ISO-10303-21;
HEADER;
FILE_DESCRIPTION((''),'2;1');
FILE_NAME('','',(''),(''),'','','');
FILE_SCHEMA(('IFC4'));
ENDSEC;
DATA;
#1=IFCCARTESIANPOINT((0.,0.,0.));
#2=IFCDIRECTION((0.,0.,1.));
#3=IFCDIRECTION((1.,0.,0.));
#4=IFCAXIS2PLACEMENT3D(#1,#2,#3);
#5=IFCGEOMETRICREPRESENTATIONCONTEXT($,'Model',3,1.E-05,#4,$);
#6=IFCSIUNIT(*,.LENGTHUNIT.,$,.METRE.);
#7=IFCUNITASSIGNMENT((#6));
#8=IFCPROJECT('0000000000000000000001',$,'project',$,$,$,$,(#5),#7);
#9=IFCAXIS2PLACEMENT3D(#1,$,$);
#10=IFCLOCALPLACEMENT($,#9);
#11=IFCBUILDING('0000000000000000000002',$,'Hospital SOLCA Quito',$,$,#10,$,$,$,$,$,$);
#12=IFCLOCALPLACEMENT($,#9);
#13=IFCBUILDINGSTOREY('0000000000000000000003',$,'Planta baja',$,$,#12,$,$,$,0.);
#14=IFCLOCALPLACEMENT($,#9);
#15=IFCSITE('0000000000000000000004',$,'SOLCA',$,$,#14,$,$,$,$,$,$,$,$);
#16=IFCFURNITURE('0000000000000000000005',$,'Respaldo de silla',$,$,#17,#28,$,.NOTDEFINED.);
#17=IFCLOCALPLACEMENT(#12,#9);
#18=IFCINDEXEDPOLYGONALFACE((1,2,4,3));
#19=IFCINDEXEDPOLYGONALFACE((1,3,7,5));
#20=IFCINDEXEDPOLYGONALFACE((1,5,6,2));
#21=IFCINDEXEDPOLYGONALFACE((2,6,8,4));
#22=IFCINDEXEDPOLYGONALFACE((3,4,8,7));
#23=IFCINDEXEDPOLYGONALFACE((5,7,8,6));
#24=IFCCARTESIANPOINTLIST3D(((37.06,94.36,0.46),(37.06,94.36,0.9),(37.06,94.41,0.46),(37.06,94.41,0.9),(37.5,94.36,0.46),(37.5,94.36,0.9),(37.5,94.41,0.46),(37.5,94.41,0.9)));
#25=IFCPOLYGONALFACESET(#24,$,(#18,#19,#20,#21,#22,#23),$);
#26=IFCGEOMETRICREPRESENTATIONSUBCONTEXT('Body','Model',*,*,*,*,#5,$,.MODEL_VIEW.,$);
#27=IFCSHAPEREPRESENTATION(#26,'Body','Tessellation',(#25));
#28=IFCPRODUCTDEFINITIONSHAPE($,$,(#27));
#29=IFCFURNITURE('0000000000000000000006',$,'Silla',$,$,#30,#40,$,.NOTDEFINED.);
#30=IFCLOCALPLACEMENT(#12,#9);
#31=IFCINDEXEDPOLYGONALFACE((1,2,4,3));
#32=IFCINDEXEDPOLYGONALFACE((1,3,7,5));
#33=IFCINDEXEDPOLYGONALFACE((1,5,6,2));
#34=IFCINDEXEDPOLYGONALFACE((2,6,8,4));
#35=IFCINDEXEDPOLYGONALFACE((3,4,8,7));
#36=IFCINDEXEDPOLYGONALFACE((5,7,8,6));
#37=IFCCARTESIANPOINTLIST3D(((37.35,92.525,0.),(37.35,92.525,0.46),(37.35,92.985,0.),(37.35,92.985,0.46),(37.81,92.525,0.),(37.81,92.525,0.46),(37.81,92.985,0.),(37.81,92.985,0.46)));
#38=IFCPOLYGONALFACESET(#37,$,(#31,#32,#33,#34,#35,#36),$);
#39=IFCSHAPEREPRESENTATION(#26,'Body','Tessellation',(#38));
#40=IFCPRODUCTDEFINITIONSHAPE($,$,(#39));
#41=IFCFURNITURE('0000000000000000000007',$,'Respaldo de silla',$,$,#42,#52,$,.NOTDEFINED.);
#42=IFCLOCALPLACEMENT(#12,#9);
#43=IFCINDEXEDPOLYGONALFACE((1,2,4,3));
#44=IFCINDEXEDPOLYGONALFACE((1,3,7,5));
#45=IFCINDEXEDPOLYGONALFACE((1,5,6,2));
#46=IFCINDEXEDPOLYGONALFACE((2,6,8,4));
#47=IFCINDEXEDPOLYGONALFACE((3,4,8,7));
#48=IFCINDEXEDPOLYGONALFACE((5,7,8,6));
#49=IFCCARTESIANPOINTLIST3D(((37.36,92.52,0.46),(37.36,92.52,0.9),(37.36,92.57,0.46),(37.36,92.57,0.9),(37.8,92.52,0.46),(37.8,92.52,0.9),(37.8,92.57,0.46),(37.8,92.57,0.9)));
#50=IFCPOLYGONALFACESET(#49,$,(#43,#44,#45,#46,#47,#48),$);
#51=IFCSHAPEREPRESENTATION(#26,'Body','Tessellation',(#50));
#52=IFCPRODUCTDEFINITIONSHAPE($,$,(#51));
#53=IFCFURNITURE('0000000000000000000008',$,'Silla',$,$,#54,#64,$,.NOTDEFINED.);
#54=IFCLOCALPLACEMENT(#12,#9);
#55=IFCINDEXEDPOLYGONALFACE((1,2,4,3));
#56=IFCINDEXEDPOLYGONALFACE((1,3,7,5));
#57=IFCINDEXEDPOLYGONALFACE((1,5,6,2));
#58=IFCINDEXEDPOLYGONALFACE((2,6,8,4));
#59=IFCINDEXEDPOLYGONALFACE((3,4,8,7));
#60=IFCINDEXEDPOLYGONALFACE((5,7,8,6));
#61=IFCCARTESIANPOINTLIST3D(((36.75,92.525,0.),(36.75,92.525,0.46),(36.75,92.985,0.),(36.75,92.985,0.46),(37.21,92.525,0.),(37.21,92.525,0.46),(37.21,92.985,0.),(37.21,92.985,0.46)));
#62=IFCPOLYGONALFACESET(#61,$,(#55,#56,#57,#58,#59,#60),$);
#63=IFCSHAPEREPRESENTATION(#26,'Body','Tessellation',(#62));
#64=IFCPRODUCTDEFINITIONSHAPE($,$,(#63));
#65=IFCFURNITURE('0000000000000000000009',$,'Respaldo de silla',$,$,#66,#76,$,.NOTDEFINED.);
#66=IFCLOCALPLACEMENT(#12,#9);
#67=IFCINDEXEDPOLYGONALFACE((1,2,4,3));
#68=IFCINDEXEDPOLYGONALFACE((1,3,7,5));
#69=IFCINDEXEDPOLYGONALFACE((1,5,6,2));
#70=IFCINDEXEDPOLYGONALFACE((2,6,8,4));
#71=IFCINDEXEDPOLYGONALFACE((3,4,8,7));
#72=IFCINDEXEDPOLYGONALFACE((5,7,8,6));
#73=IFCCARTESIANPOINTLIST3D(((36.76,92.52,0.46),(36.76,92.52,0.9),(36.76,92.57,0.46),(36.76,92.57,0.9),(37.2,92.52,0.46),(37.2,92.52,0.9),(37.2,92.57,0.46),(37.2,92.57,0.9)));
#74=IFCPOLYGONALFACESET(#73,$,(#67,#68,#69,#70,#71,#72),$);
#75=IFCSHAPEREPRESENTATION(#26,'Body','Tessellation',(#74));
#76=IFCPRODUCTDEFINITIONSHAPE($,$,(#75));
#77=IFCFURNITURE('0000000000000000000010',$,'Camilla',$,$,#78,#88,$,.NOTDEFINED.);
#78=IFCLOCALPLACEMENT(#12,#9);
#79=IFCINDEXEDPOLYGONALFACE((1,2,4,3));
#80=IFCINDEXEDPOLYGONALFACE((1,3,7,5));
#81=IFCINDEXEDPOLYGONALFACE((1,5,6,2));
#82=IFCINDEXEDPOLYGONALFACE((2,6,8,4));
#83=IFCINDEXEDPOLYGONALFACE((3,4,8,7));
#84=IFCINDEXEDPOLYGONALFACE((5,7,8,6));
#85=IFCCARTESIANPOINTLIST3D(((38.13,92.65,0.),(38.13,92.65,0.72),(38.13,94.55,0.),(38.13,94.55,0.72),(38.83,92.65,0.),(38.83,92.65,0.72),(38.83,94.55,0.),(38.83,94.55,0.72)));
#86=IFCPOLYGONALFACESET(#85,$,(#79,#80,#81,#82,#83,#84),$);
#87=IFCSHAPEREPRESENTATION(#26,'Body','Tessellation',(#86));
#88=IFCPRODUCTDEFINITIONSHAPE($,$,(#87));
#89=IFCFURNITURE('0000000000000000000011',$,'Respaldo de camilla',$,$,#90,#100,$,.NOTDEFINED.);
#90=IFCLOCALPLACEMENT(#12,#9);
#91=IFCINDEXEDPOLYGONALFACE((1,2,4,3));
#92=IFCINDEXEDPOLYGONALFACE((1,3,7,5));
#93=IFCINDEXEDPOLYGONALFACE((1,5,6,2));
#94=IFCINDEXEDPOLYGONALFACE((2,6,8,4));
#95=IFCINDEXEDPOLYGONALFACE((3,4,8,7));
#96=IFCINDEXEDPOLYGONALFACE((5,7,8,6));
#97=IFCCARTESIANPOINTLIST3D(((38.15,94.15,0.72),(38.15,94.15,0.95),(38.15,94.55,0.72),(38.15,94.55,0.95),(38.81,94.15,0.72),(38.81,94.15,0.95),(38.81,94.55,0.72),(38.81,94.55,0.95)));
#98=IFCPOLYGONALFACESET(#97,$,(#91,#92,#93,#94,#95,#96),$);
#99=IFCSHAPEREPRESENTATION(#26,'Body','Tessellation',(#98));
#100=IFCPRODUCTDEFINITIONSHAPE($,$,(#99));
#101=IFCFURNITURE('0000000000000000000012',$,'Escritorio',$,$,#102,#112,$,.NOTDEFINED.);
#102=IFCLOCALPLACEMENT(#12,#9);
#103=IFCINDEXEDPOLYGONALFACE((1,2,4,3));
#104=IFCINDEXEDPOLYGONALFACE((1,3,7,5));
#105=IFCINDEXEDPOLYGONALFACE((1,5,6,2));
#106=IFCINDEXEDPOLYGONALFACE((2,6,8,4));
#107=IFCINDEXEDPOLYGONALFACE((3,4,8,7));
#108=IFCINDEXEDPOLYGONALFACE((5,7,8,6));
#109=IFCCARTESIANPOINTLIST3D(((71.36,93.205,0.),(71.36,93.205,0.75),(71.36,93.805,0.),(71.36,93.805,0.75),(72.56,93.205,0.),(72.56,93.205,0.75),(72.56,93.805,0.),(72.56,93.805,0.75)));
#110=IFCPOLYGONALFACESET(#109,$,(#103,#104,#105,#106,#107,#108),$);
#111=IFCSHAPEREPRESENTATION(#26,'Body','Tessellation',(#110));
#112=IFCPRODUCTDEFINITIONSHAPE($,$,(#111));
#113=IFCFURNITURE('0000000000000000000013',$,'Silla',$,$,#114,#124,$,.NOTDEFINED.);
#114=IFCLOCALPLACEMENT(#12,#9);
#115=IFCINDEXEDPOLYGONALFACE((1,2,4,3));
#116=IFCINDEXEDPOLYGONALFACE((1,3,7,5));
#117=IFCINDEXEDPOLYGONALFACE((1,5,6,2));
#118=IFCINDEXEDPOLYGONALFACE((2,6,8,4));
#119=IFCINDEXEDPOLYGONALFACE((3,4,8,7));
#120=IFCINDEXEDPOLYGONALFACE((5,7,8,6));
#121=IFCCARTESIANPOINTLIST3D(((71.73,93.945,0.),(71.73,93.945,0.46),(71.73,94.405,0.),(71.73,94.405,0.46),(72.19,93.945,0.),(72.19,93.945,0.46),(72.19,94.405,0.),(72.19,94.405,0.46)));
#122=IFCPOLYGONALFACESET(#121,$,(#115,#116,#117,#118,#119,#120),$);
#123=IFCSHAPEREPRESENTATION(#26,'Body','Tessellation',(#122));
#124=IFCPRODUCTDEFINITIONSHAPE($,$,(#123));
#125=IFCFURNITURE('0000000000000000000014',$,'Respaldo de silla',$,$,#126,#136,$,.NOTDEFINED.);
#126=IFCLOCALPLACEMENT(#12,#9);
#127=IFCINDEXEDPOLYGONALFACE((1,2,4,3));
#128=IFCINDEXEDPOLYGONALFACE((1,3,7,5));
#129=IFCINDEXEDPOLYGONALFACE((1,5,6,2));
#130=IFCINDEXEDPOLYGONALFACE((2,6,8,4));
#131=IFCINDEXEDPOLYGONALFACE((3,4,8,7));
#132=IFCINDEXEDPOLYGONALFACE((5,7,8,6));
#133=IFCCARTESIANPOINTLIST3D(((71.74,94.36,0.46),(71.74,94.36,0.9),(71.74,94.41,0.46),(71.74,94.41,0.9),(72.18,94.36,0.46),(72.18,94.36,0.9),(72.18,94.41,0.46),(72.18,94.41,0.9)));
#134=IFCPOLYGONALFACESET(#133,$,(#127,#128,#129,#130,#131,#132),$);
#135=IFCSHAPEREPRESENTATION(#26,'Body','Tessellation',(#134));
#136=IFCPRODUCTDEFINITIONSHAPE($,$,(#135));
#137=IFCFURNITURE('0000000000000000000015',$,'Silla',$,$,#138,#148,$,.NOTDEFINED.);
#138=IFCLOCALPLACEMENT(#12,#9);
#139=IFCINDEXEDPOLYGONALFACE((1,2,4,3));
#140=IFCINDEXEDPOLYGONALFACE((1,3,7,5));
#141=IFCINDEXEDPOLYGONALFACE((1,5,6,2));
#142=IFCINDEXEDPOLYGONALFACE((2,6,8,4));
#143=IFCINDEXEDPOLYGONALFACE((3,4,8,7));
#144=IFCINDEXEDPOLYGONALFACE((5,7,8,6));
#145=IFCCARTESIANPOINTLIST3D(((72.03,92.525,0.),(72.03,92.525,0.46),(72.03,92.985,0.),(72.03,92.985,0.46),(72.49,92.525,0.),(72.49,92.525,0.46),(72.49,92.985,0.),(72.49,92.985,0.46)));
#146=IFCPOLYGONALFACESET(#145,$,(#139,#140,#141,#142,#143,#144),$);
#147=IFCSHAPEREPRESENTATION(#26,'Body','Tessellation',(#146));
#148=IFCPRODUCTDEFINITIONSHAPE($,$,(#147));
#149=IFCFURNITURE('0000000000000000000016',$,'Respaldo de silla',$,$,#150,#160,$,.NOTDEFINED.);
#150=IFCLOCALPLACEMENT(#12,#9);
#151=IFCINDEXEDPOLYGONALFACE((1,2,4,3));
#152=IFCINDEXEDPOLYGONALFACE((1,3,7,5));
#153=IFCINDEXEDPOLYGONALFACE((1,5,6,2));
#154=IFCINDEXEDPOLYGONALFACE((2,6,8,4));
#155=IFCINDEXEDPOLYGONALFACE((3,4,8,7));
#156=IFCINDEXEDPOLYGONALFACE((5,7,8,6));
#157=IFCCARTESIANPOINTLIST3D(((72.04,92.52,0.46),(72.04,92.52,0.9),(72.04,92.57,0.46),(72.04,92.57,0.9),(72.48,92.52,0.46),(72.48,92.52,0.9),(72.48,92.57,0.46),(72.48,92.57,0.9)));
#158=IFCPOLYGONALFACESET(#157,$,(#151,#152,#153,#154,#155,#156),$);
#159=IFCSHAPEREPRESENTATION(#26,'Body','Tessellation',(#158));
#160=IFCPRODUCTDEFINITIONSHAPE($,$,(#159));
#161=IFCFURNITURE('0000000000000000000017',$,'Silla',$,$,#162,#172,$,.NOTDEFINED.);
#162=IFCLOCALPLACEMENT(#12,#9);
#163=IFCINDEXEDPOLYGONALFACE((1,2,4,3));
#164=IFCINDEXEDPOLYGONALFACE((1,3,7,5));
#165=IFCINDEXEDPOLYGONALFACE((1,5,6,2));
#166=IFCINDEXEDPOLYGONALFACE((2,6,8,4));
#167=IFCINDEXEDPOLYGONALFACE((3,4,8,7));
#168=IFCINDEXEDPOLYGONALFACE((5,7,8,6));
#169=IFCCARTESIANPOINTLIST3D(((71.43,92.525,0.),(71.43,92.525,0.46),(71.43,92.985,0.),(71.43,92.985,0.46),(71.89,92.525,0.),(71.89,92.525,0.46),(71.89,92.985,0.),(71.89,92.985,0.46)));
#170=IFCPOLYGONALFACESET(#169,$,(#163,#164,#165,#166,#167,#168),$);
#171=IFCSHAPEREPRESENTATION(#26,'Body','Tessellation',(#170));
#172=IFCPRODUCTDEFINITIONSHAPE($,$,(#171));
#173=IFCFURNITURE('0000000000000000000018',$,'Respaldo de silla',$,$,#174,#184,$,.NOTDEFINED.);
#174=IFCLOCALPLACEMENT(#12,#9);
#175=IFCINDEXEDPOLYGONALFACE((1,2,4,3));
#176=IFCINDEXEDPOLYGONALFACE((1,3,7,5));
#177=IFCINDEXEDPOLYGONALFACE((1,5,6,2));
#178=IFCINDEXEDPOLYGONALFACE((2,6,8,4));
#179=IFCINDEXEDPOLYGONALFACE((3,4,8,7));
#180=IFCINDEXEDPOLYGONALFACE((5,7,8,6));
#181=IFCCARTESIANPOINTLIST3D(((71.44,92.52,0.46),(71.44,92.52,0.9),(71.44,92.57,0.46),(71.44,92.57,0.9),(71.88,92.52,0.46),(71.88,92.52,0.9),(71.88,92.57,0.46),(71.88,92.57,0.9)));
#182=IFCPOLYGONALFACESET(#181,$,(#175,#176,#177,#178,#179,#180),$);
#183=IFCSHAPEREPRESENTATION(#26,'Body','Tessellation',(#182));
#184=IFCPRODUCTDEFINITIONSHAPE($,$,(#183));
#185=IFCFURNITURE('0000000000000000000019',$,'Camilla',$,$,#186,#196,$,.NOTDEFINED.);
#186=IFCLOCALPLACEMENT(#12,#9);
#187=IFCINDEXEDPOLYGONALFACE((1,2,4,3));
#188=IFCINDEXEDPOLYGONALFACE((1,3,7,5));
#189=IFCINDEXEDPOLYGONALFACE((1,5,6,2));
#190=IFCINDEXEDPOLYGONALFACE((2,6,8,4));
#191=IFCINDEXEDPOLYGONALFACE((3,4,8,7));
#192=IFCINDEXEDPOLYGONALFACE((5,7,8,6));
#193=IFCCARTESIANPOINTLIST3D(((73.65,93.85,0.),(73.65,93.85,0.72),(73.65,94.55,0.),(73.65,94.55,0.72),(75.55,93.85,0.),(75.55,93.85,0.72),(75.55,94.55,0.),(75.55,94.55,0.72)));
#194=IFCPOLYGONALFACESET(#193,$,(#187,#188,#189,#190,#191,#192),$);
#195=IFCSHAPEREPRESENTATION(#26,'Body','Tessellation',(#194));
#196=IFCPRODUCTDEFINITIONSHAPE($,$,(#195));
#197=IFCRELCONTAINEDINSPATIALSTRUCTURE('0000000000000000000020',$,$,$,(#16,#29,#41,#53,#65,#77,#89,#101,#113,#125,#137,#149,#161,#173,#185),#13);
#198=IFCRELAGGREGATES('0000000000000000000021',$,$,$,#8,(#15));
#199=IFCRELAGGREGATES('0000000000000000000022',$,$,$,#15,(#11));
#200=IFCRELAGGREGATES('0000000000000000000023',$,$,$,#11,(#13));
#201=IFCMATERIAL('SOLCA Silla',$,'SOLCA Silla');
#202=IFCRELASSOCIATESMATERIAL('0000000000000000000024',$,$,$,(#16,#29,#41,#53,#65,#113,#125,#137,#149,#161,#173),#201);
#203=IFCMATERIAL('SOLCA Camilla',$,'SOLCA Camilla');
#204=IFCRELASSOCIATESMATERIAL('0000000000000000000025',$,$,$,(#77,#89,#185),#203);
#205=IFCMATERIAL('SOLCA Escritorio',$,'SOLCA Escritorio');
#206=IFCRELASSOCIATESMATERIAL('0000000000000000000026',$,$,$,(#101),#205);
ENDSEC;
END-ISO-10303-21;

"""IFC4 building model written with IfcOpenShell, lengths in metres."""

from ifc_helpers import new_model, si_unit, frame, origin, origin_with_axes, place, context, subcontext, project, spatial, polyline, outline, extrude, material, element, save


model = new_model("IFC4")

# Units and contexts
model_context = context("Model", 3, precision=1e-05, world=origin_with_axes())
body_context = subcontext(model_context, "Body", "Model", "MODEL_VIEW")
ifc_project = project(units=[si_unit("LENGTHUNIT", "METRE")], contexts=[model_context])

# Site, building, storey
site_placement = place(None, origin())
site = spatial("IfcSite", under=ifc_project, at=site_placement, Name="SOLCA")
building_placement = place(None, origin())
building = spatial("IfcBuilding", under=site, at=building_placement, Name="Hospital SOLCA Quito")
storey_placement = place(None, origin())
storey = spatial("IfcBuildingStorey", under=building, at=storey_placement, Name="Planta baja", Elevation=0.0)

# Furniture
ifc_material_1 = material(Name="SOLCA Silla", Category="SOLCA Silla")
furniture_1_placement = place(storey_placement, origin_with_axes())
element("IfcFurniture", 1, at=furniture_1_placement, inside=storey, material=ifc_material_1, Name="Respaldo de silla", PredefinedType="NOTDEFINED", context=body_context, shape_type="SweptSolid", body=[
    extrude(outline(polyline([(37.5, 94.41), (37.06, 94.41), (37.06, 94.36), (37.5, 94.36), (37.5, 94.41)])), frame((0.0, 0.0, 0.46), z_axis=(0.0, 0.0, 1.0), x_axis=(1.0, 0.0, 0.0)), (0.0, 0.0, 1.0), 0.44),
])
furniture_2_placement = place(storey_placement, origin_with_axes())
element("IfcFurniture", 2, at=furniture_2_placement, inside=storey, material=ifc_material_1, Name="Silla", PredefinedType="NOTDEFINED", context=body_context, shape_type="SweptSolid", body=[
    extrude(outline(polyline([(37.81, 92.985), (37.35, 92.985), (37.35, 92.525), (37.81, 92.525), (37.81, 92.985)])), origin_with_axes(), (0.0, 0.0, 1.0), 0.46),
])
furniture_3_placement = place(storey_placement, origin_with_axes())
element("IfcFurniture", 3, at=furniture_3_placement, inside=storey, material=ifc_material_1, Name="Respaldo de silla", PredefinedType="NOTDEFINED", context=body_context, shape_type="SweptSolid", body=[
    extrude(outline(polyline([(37.8, 92.57), (37.36, 92.57), (37.36, 92.52), (37.8, 92.52), (37.8, 92.57)])), frame((0.0, 0.0, 0.46), z_axis=(0.0, 0.0, 1.0), x_axis=(1.0, 0.0, 0.0)), (0.0, 0.0, 1.0), 0.44),
])
furniture_4_placement = place(storey_placement, origin_with_axes())
element("IfcFurniture", 4, at=furniture_4_placement, inside=storey, material=ifc_material_1, Name="Silla", PredefinedType="NOTDEFINED", context=body_context, shape_type="SweptSolid", body=[
    extrude(outline(polyline([(37.21, 92.985), (36.75, 92.985), (36.75, 92.525), (37.21, 92.525), (37.21, 92.985)])), origin_with_axes(), (0.0, 0.0, 1.0), 0.46),
])
furniture_5_placement = place(storey_placement, origin_with_axes())
element("IfcFurniture", 5, at=furniture_5_placement, inside=storey, material=ifc_material_1, Name="Respaldo de silla", PredefinedType="NOTDEFINED", context=body_context, shape_type="SweptSolid", body=[
    extrude(outline(polyline([(37.2, 92.57), (36.76, 92.57), (36.76, 92.52), (37.2, 92.52), (37.2, 92.57)])), frame((0.0, 0.0, 0.46), z_axis=(0.0, 0.0, 1.0), x_axis=(1.0, 0.0, 0.0)), (0.0, 0.0, 1.0), 0.44),
])
ifc_material_2 = material(Name="SOLCA Camilla", Category="SOLCA Camilla")
furniture_6_placement = place(storey_placement, origin_with_axes())
element("IfcFurniture", 6, at=furniture_6_placement, inside=storey, material=ifc_material_2, Name="Camilla", PredefinedType="NOTDEFINED", context=body_context, shape_type="SweptSolid", body=[
    extrude(outline(polyline([(38.83, 92.65), (38.83, 94.55), (38.13, 94.55), (38.13, 92.65), (38.83, 92.65)])), origin_with_axes(), (0.0, 0.0, 1.0), 0.72),
])
furniture_7_placement = place(storey_placement, origin_with_axes())
element("IfcFurniture", 7, at=furniture_7_placement, inside=storey, material=ifc_material_2, Name="Respaldo de camilla", PredefinedType="NOTDEFINED", context=body_context, shape_type="SweptSolid", body=[
    extrude(outline(polyline([(38.81, 94.15), (38.81, 94.55), (38.15, 94.55), (38.15, 94.15), (38.81, 94.15)])), frame((0.0, 0.0, 0.72), z_axis=(0.0, 0.0, 1.0), x_axis=(1.0, 0.0, 0.0)), (0.0, 0.0, 1.0), 0.23),
])
ifc_material_3 = material(Name="SOLCA Escritorio", Category="SOLCA Escritorio")
furniture_8_placement = place(storey_placement, origin_with_axes())
element("IfcFurniture", 8, at=furniture_8_placement, inside=storey, material=ifc_material_3, Name="Escritorio", PredefinedType="NOTDEFINED", context=body_context, shape_type="SweptSolid", body=[
    extrude(outline(polyline([(72.56, 93.805), (71.36, 93.805), (71.36, 93.205), (72.56, 93.205), (72.56, 93.805)])), origin_with_axes(), (0.0, 0.0, 1.0), 0.75),
])
furniture_9_placement = place(storey_placement, origin_with_axes())
element("IfcFurniture", 9, at=furniture_9_placement, inside=storey, material=ifc_material_1, Name="Silla", PredefinedType="NOTDEFINED", context=body_context, shape_type="SweptSolid", body=[
    extrude(outline(polyline([(72.19, 94.405), (71.73, 94.405), (71.73, 93.945), (72.19, 93.945), (72.19, 94.405)])), origin_with_axes(), (0.0, 0.0, 1.0), 0.46),
])
furniture_10_placement = place(storey_placement, origin_with_axes())
element("IfcFurniture", 10, at=furniture_10_placement, inside=storey, material=ifc_material_1, Name="Respaldo de silla", PredefinedType="NOTDEFINED", context=body_context, shape_type="SweptSolid", body=[
    extrude(outline(polyline([(72.18, 94.41), (71.74, 94.41), (71.74, 94.36), (72.18, 94.36), (72.18, 94.41)])), frame((0.0, 0.0, 0.46), z_axis=(0.0, 0.0, 1.0), x_axis=(1.0, 0.0, 0.0)), (0.0, 0.0, 1.0), 0.44),
])
furniture_11_placement = place(storey_placement, origin_with_axes())
element("IfcFurniture", 11, at=furniture_11_placement, inside=storey, material=ifc_material_1, Name="Silla", PredefinedType="NOTDEFINED", context=body_context, shape_type="SweptSolid", body=[
    extrude(outline(polyline([(72.49, 92.985), (72.03, 92.985), (72.03, 92.525), (72.49, 92.525), (72.49, 92.985)])), origin_with_axes(), (0.0, 0.0, 1.0), 0.46),
])
furniture_12_placement = place(storey_placement, origin_with_axes())
element("IfcFurniture", 12, at=furniture_12_placement, inside=storey, material=ifc_material_1, Name="Respaldo de silla", PredefinedType="NOTDEFINED", context=body_context, shape_type="SweptSolid", body=[
    extrude(outline(polyline([(72.48, 92.57), (72.04, 92.57), (72.04, 92.52), (72.48, 92.52), (72.48, 92.57)])), frame((0.0, 0.0, 0.46), z_axis=(0.0, 0.0, 1.0), x_axis=(1.0, 0.0, 0.0)), (0.0, 0.0, 1.0), 0.44),
])
furniture_13_placement = place(storey_placement, origin_with_axes())
element("IfcFurniture", 13, at=furniture_13_placement, inside=storey, material=ifc_material_1, Name="Silla", PredefinedType="NOTDEFINED", context=body_context, shape_type="SweptSolid", body=[
    extrude(outline(polyline([(71.89, 92.985), (71.43, 92.985), (71.43, 92.525), (71.89, 92.525), (71.89, 92.985)])), origin_with_axes(), (0.0, 0.0, 1.0), 0.46),
])
furniture_14_placement = place(storey_placement, origin_with_axes())
element("IfcFurniture", 14, at=furniture_14_placement, inside=storey, material=ifc_material_1, Name="Respaldo de silla", PredefinedType="NOTDEFINED", context=body_context, shape_type="SweptSolid", body=[
    extrude(outline(polyline([(71.88, 92.57), (71.44, 92.57), (71.44, 92.52), (71.88, 92.52), (71.88, 92.57)])), frame((0.0, 0.0, 0.46), z_axis=(0.0, 0.0, 1.0), x_axis=(1.0, 0.0, 0.0)), (0.0, 0.0, 1.0), 0.44),
])
furniture_15_placement = place(storey_placement, origin_with_axes())
element("IfcFurniture", 15, at=furniture_15_placement, inside=storey, material=ifc_material_2, Name="Camilla", PredefinedType="NOTDEFINED", context=body_context, shape_type="SweptSolid", body=[
    extrude(outline(polyline([(75.55, 94.55), (73.65, 94.55), (73.65, 93.85), (75.55, 93.85), (75.55, 94.55)])), origin_with_axes(), (0.0, 0.0, 1.0), 0.72),
])

save(model, "model.ifc")
